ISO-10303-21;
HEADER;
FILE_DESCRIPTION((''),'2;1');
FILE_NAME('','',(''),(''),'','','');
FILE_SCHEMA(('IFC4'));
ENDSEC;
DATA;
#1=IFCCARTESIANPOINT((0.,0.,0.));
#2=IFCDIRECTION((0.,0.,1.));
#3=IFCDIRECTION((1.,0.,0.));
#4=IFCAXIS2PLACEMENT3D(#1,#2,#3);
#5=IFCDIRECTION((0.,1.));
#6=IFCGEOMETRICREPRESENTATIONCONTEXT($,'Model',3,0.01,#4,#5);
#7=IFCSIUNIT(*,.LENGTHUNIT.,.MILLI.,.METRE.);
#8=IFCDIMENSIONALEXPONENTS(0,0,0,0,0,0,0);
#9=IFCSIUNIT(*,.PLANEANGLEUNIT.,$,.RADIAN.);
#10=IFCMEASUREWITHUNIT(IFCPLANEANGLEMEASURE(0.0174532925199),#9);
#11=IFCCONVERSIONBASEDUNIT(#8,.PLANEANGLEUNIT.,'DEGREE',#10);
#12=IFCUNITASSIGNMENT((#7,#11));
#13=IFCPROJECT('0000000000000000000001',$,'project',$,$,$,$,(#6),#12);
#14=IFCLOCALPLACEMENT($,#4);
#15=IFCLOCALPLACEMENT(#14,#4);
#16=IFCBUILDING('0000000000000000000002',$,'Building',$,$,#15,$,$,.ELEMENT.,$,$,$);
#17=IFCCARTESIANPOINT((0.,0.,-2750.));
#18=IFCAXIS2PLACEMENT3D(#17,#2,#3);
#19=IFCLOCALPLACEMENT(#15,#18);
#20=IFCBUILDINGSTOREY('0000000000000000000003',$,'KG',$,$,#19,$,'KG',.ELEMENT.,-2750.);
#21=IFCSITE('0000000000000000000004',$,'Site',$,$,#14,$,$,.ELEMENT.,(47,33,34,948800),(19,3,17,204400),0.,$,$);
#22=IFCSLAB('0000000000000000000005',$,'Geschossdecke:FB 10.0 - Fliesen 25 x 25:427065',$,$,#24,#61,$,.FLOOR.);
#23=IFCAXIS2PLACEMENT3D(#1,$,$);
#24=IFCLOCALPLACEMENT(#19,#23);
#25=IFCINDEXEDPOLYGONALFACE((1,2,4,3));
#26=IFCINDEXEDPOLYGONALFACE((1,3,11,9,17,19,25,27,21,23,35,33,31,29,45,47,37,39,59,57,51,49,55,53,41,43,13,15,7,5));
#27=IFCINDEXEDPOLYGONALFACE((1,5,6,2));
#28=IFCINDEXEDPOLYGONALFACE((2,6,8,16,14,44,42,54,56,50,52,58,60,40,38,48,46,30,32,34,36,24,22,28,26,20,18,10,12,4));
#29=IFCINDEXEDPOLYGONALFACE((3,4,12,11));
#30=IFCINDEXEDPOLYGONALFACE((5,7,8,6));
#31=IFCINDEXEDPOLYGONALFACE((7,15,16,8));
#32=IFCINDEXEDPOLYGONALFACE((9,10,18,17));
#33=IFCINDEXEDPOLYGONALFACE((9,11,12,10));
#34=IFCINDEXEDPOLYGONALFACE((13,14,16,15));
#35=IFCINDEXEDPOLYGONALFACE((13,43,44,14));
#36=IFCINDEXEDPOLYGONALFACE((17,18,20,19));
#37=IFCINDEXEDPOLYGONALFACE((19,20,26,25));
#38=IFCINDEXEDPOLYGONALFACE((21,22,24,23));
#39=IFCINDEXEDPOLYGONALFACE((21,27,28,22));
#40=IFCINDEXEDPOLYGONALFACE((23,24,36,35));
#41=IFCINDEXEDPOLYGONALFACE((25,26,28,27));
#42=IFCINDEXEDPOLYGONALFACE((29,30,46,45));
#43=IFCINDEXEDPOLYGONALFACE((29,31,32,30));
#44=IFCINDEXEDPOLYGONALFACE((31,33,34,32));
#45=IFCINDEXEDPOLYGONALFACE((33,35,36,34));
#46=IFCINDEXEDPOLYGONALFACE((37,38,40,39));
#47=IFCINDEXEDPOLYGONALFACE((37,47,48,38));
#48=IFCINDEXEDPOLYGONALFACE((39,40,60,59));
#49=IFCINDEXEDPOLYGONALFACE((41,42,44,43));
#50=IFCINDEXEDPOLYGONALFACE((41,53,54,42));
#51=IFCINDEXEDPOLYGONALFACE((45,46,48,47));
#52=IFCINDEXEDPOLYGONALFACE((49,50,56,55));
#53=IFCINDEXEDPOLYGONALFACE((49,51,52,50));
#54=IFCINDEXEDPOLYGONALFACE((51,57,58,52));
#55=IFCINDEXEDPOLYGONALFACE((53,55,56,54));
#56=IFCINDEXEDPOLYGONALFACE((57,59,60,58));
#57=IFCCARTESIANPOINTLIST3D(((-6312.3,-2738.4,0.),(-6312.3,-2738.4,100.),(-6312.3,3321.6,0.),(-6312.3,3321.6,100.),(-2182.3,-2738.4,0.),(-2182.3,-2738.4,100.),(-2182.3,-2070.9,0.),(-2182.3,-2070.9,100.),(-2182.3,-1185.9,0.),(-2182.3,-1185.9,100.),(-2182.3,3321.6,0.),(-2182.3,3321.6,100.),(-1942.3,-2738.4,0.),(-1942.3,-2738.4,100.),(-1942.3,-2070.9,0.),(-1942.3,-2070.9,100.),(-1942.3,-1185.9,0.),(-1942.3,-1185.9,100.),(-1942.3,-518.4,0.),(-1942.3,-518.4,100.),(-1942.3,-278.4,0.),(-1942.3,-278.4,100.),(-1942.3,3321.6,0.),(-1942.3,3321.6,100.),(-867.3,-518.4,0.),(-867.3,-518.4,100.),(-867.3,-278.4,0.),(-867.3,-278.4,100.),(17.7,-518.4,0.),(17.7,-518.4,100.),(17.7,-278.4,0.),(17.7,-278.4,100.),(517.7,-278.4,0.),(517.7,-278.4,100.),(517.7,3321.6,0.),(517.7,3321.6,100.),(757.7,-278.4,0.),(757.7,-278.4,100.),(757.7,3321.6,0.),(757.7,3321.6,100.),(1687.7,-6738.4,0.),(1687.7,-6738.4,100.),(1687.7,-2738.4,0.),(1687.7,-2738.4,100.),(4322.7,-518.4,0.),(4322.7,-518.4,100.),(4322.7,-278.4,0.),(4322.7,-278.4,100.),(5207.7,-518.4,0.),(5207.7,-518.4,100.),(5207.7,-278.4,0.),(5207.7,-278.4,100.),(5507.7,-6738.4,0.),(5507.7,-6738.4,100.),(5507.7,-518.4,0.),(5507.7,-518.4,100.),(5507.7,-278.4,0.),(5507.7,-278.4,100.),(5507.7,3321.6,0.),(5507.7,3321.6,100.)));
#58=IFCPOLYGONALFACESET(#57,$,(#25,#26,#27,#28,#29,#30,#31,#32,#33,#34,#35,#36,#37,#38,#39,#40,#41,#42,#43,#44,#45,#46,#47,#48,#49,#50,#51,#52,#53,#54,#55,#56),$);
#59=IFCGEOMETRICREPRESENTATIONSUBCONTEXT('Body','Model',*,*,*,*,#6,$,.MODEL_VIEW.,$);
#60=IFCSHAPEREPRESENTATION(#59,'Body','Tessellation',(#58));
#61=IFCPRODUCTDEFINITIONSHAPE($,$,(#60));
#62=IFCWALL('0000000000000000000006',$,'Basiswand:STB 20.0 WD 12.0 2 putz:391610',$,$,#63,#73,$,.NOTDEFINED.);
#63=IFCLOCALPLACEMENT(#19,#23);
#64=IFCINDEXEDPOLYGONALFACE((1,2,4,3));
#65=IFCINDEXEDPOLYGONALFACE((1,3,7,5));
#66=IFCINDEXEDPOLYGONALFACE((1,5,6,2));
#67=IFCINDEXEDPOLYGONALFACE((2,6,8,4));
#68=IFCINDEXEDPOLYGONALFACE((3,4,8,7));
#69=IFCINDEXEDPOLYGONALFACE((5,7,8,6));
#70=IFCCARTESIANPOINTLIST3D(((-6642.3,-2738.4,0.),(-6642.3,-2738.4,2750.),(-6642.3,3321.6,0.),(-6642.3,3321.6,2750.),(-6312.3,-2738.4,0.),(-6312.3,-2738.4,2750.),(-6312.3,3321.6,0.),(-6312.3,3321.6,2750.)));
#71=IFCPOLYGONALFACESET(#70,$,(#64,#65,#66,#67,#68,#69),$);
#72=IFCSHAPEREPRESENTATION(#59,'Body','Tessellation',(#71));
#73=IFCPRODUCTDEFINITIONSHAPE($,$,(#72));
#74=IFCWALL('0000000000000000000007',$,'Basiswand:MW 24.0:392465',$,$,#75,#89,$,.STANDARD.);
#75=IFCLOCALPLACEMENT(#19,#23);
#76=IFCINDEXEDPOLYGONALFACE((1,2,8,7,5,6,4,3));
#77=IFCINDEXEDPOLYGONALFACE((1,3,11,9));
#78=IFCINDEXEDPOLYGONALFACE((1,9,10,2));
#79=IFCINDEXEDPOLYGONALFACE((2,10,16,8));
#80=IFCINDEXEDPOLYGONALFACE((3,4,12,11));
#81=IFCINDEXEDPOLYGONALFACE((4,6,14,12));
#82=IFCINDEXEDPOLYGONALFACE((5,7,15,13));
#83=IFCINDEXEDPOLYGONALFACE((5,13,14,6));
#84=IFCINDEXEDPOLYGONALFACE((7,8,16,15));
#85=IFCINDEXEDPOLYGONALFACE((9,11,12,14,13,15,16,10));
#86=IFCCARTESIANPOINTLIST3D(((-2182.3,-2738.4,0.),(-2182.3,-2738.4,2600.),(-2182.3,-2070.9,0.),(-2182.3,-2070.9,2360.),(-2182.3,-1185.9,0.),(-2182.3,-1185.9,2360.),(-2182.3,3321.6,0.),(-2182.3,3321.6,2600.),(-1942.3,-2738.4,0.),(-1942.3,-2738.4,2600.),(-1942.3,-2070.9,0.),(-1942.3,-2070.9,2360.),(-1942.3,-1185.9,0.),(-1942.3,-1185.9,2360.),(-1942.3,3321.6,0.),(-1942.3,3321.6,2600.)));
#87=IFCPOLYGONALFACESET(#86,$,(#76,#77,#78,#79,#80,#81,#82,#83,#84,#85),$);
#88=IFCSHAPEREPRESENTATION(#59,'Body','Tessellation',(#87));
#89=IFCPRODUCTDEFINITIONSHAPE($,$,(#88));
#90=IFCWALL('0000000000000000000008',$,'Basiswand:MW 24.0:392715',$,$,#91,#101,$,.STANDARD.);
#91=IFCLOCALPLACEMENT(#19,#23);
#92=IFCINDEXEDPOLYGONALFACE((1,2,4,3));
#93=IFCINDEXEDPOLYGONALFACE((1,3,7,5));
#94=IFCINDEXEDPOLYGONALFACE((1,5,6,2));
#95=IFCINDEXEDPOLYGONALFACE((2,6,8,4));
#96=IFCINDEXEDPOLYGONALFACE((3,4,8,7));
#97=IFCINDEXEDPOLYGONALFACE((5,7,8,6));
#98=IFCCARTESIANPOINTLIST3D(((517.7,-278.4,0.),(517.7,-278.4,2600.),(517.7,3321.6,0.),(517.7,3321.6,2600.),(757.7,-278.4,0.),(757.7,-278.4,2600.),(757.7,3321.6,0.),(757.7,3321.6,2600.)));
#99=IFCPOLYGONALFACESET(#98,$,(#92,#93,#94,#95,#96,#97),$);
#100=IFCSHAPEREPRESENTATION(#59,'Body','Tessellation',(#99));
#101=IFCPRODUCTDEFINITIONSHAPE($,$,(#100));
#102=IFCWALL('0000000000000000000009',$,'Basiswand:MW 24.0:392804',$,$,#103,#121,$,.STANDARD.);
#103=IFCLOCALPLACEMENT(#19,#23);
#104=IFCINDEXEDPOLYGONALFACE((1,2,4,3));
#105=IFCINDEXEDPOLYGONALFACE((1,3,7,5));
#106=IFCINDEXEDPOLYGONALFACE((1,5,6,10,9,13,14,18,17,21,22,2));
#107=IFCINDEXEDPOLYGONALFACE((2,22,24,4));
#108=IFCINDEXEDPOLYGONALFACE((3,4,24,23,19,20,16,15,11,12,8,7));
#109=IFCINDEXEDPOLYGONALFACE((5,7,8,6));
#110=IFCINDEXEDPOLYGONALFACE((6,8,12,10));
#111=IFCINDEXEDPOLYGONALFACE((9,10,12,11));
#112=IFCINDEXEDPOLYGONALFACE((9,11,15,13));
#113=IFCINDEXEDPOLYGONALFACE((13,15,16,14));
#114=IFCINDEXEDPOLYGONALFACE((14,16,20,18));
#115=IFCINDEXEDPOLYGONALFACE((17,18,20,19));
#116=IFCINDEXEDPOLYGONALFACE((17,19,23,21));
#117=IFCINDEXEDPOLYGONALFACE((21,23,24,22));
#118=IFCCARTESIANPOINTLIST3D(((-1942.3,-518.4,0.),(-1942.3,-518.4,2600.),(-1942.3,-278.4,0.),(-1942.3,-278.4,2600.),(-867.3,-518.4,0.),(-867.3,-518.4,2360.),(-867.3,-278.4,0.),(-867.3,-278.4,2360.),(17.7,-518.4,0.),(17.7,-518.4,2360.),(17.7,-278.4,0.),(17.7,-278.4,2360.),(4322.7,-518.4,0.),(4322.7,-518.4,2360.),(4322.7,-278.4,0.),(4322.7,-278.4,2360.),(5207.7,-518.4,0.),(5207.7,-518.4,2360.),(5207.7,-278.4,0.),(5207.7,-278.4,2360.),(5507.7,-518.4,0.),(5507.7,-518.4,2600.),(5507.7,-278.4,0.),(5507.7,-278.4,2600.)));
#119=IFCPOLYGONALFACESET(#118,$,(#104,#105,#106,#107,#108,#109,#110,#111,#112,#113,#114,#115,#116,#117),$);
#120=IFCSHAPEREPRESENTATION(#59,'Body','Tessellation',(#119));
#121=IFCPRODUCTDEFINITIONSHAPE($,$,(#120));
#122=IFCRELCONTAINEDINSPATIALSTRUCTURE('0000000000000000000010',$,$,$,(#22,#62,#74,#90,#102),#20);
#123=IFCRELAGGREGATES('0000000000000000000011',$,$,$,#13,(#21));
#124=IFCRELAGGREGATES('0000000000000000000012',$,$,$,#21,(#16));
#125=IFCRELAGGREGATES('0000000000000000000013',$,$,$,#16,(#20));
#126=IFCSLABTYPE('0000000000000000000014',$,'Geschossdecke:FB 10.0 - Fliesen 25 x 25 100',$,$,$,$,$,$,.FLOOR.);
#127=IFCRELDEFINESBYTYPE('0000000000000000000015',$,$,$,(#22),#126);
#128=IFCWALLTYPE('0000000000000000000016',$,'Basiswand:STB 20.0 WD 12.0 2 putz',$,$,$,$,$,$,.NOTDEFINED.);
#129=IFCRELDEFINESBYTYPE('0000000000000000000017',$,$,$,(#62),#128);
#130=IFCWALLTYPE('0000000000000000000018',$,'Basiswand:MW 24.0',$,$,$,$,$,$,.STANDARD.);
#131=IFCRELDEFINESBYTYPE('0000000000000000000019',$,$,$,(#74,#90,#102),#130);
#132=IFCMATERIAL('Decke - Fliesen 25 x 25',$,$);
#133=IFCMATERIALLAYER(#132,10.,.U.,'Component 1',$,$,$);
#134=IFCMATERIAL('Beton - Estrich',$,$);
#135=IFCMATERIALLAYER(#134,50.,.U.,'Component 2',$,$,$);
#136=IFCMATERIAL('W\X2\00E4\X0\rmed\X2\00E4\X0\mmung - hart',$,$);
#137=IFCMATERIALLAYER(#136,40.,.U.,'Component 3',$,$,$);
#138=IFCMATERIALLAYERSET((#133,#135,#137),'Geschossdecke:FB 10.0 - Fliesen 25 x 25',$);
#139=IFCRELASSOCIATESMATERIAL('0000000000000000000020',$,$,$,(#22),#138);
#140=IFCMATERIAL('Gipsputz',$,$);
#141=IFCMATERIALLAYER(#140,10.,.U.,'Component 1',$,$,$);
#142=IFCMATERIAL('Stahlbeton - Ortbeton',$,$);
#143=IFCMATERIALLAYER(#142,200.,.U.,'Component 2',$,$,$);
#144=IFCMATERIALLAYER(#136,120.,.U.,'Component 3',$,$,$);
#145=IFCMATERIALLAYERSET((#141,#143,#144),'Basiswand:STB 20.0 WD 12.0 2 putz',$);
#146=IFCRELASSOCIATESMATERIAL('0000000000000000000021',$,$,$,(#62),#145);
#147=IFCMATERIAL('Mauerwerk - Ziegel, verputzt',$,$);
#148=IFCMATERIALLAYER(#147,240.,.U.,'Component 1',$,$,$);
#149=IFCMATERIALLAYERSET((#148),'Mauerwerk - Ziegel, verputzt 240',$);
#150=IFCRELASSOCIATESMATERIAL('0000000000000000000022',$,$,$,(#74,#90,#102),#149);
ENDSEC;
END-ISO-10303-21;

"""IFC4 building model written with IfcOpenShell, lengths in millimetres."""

from ifc_helpers import new_model, entity, si_unit, converted_unit, direction, frame, origin_with_axes, place, context, subcontext, project, spatial, line, indexed_curve, outline, extrude, material, layer, layer_set, layer_usage, type_object, element, save


model = new_model("IFC4")

# Units and contexts
model_context = context("Model", 3, precision=0.01, world=origin_with_axes(), true_north=direction((0.0, 1.0)))
body_context = subcontext(model_context, "Body", "Model", "MODEL_VIEW")
ifc_project = project(units=[si_unit("LENGTHUNIT", "METRE", prefix="MILLI"), converted_unit("PLANEANGLEUNIT", "DEGREE", entity("IfcPlaneAngleMeasure", 0.0174532925199), si_unit("PLANEANGLEUNIT", "RADIAN"), dimensions=[0, 0, 0, 0, 0, 0, 0])], contexts=[model_context])

# Site, building, storey
site_placement = place(None, origin_with_axes())
site = spatial("IfcSite", under=ifc_project, at=site_placement, Name="Site", CompositionType="ELEMENT", RefLatitude=(47, 33, 34, 948800), RefLongitude=(19, 3, 17, 204400), RefElevation=0.0)
building_placement = place(site_placement, origin_with_axes())
building = spatial("IfcBuilding", under=site, at=building_placement, Name="Building", CompositionType="ELEMENT")
storey_placement = place(building_placement, frame((0.0, 0.0, -2750.0), z_axis=(0.0, 0.0, 1.0), x_axis=(1.0, 0.0, 0.0)))
storey = spatial("IfcBuildingStorey", under=building, at=storey_placement, Name="KG", LongName="KG", CompositionType="ELEMENT", Elevation=-2750.0)

# Slab
ifc_material_1 = material(Name="Decke - Fliesen 25 x 25")
ifc_layer_1 = layer(ifc_material_1, 10.0, ventilated="UNKNOWN", Name="Component 1")
ifc_material_2 = material(Name="Beton - Estrich")
ifc_layer_2 = layer(ifc_material_2, 50.0, ventilated="UNKNOWN", Name="Component 2")
ifc_material_3 = material(Name="Wärmedämmung - hart")
ifc_layer_3 = layer(ifc_material_3, 40.0, ventilated="UNKNOWN", Name="Component 3")
ifc_layer_set_1 = layer_set([ifc_layer_1, ifc_layer_2, ifc_layer_3], Name="Geschossdecke:FB 10.0 - Fliesen 25 x 25")
ifc_layer_usage_1 = layer_usage(ifc_layer_set_1, "AXIS3", "NEGATIVE", 100.0)
slab_type = type_object("IfcSlabType", Name="Geschossdecke:FB 10.0 - Fliesen 25 x 25 100", PredefinedType="FLOOR")
slab_placement = place(storey_placement, frame((-6312.3, -2738.4, 0.0), z_axis=(0.0, 0.0, 1.0), x_axis=(1.0, 0.0, 0.0)))
element("IfcSlab", 1, at=slab_placement, inside=storey, type_object=slab_type, material=ifc_layer_usage_1, Name="Geschossdecke:FB 10.0 - Fliesen 25 x 25:427065", PredefinedType="FLOOR", context=body_context, shape_type="SweptSolid", body=[
    extrude(outline(indexed_curve([(0.0, 0.0), (4130.0, 0.0), (4130.0, 667.5), (4370.0, 667.5), (4370.0, 0.0), (8000.0, 0.0), (8000.0, -4000.0), (11820.0, -4000.0), (11820.0, 2220.0), (11520.0, 2220.0), (11520.0, 2460.0), (11820.0, 2460.0), (11820.0, 6060.0), (7070.0, 6060.0), (7070.0, 2460.0), (10635.0, 2460.0), (10635.0, 2220.0), (6330.0, 2220.0), (6330.0, 2460.0), (6830.0, 2460.0), (6830.0, 6060.0), (4370.0, 6060.0), (4370.0, 2460.0), (5445.0, 2460.0), (5445.0, 2220.0), (4370.0, 2220.0), (4370.0, 1552.5), (4130.0, 1552.5), (4130.0, 6060.0), (0.0, 6060.0)], segments=[line(1, 2, 3, 4, 5, 6, 7, 8, 9, 10, 11, 12, 13, 14, 15, 16, 17, 18, 19, 20, 21, 22, 23, 24, 25, 26, 27, 28, 29, 30, 1)])), origin_with_axes(), (0.0, 0.0, 1.0), 100.0),
])

# Wall
ifc_material_4 = material(Name="Gipsputz")
ifc_layer_4 = layer(ifc_material_4, 10.0, ventilated="UNKNOWN", Name="Component 1")
ifc_material_5 = material(Name="Stahlbeton - Ortbeton")
ifc_layer_5 = layer(ifc_material_5, 200.0, ventilated="UNKNOWN", Name="Component 2")
ifc_layer_6 = layer(ifc_material_3, 120.0, ventilated="UNKNOWN", Name="Component 3")
ifc_layer_set_2 = layer_set([ifc_layer_4, ifc_layer_5, ifc_layer_6], Name="Basiswand:STB 20.0 WD 12.0 2 putz")
ifc_layer_usage_2 = layer_usage(ifc_layer_set_2, "AXIS2", "POSITIVE", -165.0)
wall_type_1 = type_object("IfcWallType", Name="Basiswand:STB 20.0 WD 12.0 2 putz", PredefinedType="NOTDEFINED")
wall_1_placement = place(storey_placement, frame((-6477.3, -2738.4, 0.0), z_axis=(0.0, 0.0, 1.0), x_axis=(0.0, 1.0, 0.0)))
element("IfcWall", 2, at=wall_1_placement, inside=storey, type_object=wall_type_1, material=ifc_layer_usage_2, Name="Basiswand:STB 20.0 WD 12.0 2 putz:391610", PredefinedType="NOTDEFINED", context=body_context, shape_type="SweptSolid", body=[
    extrude(outline(indexed_curve([(0.0, -165.0), (6060.0, -165.0), (6060.0, 165.0), (0.0, 165.0)], segments=[line(1, 2, 3, 4, 1)])), origin_with_axes(), (0.0, 0.0, 1.0), 2750.0),
])

# Wall, opening
ifc_material_6 = material(Name="Mauerwerk - Ziegel, verputzt")
ifc_layer_7 = layer(ifc_material_6, 240.0, ventilated="UNKNOWN", Name="Component 1")
ifc_layer_set_3 = layer_set([ifc_layer_7], Name="Mauerwerk - Ziegel, verputzt 240")
ifc_layer_usage_3 = layer_usage(ifc_layer_set_3, "AXIS2", "POSITIVE", -120.0)
wall_type_2 = type_object("IfcWallType", Name="Basiswand:MW 24.0", PredefinedType="STANDARD")
wall_2_placement = place(storey_placement, frame((-2062.3, 3321.6, 0.0), z_axis=(0.0, 0.0, 1.0), x_axis=(0.0, -1.0, 0.0)))
wall_2 = element("IfcWall", 3, at=wall_2_placement, inside=storey, type_object=wall_type_2, material=ifc_layer_usage_3, Name="Basiswand:MW 24.0:392465", PredefinedType="STANDARD", context=body_context, shape_type="SweptSolid", body=[
    extrude(outline(indexed_curve([(0.0, -120.0), (6060.0, -120.0), (6060.0, 120.0), (0.0, 120.0)], segments=[line(1, 2, 3, 4, 1)])), origin_with_axes(), (0.0, 0.0, 1.0), 2600.0),
])
opening_1_placement = place(wall_2_placement, frame((4950.0, 0.0, 0.0), z_axis=(0.0, 0.0, 1.0), x_axis=(1.0, 0.0, 0.0)))
element("IfcOpeningElement", 4, at=opening_1_placement, cuts=wall_2, context=body_context, shape_type="SweptSolid", body=[
    extrude(outline(indexed_curve([(-442.5, 0.0), (-442.5, -2360.0), (442.5, -2360.0), (442.5, 0.0)], segments=[line(1, 2, 3, 4, 1)])), frame((0.0, 120.0, 0.0), z_axis=(0.0, 1.0, 0.0), x_axis=(1.0, 0.0, 0.0)), (0.0, 0.0, -1.0), 240.0),
])

# Wall
ifc_layer_usage_4 = layer_usage(ifc_layer_set_3, "AXIS2", "POSITIVE", -120.0)
wall_3_placement = place(storey_placement, frame((637.7, 3321.6, 0.0), z_axis=(0.0, 0.0, 1.0), x_axis=(0.0, -1.0, 0.0)))
element("IfcWall", 5, at=wall_3_placement, inside=storey, type_object=wall_type_2, material=ifc_layer_usage_4, Name="Basiswand:MW 24.0:392715", PredefinedType="STANDARD", context=body_context, shape_type="SweptSolid", body=[
    extrude(outline(indexed_curve([(0.0, -120.0), (3600.0, -120.0), (3600.0, 120.0), (0.0, 120.0)], segments=[line(1, 2, 3, 4, 1)])), origin_with_axes(), (0.0, 0.0, 1.0), 2600.0),
])

# Wall, openings
ifc_layer_usage_5 = layer_usage(ifc_layer_set_3, "AXIS2", "POSITIVE", -120.0)
wall_4_placement = place(storey_placement, frame((-2062.3, -398.4, 0.0), z_axis=(0.0, 0.0, 1.0), x_axis=(1.0, 0.0, 0.0)))
wall_4 = element("IfcWall", 6, at=wall_4_placement, inside=storey, type_object=wall_type_2, material=ifc_layer_usage_5, Name="Basiswand:MW 24.0:392804", PredefinedType="STANDARD", context=body_context, shape_type="SweptSolid", body=[
    extrude(outline(indexed_curve([(120.0, -120.0), (7570.0, -120.0), (7570.0, 120.0), (120.0, 120.0)], segments=[line(1, 2, 3, 4, 1)])), origin_with_axes(), (0.0, 0.0, 1.0), 2600.0),
])
opening_2_placement = place(wall_4_placement, frame((1637.5, 0.0, 0.0), z_axis=(0.0, 0.0, 1.0), x_axis=(1.0, 0.0, 0.0)))
element("IfcOpeningElement", 7, at=opening_2_placement, cuts=wall_4, context=body_context, shape_type="SweptSolid", body=[
    extrude(outline(indexed_curve([(-442.5, -2360.0), (442.5, -2360.0), (442.5, 0.0), (-442.5, 0.0)], segments=[line(1, 2, 3, 4, 1)])), frame((0.0, -120.0, 0.0), z_axis=(0.0, 1.0, 0.0), x_axis=(1.0, 0.0, 0.0)), (0.0, 0.0, 1.0), 240.0),
])
opening_3_placement = place(wall_4_placement, frame((6827.5, 0.0, 0.0), z_axis=(0.0, 0.0, 1.0), x_axis=(1.0, 0.0, 0.0)))
element("IfcOpeningElement", 8, at=opening_3_placement, cuts=wall_4, context=body_context, shape_type="SweptSolid", body=[
    extrude(outline(indexed_curve([(-442.5, -2360.0), (442.5, -2360.0), (442.5, 0.0), (-442.5, 0.0)], segments=[line(1, 2, 3, 4, 1)])), frame((0.0, -120.0, 0.0), z_axis=(0.0, 1.0, 0.0), x_axis=(1.0, 0.0, 0.0)), (0.0, 0.0, 1.0), 240.0),
])

save(model, "model.ifc")
